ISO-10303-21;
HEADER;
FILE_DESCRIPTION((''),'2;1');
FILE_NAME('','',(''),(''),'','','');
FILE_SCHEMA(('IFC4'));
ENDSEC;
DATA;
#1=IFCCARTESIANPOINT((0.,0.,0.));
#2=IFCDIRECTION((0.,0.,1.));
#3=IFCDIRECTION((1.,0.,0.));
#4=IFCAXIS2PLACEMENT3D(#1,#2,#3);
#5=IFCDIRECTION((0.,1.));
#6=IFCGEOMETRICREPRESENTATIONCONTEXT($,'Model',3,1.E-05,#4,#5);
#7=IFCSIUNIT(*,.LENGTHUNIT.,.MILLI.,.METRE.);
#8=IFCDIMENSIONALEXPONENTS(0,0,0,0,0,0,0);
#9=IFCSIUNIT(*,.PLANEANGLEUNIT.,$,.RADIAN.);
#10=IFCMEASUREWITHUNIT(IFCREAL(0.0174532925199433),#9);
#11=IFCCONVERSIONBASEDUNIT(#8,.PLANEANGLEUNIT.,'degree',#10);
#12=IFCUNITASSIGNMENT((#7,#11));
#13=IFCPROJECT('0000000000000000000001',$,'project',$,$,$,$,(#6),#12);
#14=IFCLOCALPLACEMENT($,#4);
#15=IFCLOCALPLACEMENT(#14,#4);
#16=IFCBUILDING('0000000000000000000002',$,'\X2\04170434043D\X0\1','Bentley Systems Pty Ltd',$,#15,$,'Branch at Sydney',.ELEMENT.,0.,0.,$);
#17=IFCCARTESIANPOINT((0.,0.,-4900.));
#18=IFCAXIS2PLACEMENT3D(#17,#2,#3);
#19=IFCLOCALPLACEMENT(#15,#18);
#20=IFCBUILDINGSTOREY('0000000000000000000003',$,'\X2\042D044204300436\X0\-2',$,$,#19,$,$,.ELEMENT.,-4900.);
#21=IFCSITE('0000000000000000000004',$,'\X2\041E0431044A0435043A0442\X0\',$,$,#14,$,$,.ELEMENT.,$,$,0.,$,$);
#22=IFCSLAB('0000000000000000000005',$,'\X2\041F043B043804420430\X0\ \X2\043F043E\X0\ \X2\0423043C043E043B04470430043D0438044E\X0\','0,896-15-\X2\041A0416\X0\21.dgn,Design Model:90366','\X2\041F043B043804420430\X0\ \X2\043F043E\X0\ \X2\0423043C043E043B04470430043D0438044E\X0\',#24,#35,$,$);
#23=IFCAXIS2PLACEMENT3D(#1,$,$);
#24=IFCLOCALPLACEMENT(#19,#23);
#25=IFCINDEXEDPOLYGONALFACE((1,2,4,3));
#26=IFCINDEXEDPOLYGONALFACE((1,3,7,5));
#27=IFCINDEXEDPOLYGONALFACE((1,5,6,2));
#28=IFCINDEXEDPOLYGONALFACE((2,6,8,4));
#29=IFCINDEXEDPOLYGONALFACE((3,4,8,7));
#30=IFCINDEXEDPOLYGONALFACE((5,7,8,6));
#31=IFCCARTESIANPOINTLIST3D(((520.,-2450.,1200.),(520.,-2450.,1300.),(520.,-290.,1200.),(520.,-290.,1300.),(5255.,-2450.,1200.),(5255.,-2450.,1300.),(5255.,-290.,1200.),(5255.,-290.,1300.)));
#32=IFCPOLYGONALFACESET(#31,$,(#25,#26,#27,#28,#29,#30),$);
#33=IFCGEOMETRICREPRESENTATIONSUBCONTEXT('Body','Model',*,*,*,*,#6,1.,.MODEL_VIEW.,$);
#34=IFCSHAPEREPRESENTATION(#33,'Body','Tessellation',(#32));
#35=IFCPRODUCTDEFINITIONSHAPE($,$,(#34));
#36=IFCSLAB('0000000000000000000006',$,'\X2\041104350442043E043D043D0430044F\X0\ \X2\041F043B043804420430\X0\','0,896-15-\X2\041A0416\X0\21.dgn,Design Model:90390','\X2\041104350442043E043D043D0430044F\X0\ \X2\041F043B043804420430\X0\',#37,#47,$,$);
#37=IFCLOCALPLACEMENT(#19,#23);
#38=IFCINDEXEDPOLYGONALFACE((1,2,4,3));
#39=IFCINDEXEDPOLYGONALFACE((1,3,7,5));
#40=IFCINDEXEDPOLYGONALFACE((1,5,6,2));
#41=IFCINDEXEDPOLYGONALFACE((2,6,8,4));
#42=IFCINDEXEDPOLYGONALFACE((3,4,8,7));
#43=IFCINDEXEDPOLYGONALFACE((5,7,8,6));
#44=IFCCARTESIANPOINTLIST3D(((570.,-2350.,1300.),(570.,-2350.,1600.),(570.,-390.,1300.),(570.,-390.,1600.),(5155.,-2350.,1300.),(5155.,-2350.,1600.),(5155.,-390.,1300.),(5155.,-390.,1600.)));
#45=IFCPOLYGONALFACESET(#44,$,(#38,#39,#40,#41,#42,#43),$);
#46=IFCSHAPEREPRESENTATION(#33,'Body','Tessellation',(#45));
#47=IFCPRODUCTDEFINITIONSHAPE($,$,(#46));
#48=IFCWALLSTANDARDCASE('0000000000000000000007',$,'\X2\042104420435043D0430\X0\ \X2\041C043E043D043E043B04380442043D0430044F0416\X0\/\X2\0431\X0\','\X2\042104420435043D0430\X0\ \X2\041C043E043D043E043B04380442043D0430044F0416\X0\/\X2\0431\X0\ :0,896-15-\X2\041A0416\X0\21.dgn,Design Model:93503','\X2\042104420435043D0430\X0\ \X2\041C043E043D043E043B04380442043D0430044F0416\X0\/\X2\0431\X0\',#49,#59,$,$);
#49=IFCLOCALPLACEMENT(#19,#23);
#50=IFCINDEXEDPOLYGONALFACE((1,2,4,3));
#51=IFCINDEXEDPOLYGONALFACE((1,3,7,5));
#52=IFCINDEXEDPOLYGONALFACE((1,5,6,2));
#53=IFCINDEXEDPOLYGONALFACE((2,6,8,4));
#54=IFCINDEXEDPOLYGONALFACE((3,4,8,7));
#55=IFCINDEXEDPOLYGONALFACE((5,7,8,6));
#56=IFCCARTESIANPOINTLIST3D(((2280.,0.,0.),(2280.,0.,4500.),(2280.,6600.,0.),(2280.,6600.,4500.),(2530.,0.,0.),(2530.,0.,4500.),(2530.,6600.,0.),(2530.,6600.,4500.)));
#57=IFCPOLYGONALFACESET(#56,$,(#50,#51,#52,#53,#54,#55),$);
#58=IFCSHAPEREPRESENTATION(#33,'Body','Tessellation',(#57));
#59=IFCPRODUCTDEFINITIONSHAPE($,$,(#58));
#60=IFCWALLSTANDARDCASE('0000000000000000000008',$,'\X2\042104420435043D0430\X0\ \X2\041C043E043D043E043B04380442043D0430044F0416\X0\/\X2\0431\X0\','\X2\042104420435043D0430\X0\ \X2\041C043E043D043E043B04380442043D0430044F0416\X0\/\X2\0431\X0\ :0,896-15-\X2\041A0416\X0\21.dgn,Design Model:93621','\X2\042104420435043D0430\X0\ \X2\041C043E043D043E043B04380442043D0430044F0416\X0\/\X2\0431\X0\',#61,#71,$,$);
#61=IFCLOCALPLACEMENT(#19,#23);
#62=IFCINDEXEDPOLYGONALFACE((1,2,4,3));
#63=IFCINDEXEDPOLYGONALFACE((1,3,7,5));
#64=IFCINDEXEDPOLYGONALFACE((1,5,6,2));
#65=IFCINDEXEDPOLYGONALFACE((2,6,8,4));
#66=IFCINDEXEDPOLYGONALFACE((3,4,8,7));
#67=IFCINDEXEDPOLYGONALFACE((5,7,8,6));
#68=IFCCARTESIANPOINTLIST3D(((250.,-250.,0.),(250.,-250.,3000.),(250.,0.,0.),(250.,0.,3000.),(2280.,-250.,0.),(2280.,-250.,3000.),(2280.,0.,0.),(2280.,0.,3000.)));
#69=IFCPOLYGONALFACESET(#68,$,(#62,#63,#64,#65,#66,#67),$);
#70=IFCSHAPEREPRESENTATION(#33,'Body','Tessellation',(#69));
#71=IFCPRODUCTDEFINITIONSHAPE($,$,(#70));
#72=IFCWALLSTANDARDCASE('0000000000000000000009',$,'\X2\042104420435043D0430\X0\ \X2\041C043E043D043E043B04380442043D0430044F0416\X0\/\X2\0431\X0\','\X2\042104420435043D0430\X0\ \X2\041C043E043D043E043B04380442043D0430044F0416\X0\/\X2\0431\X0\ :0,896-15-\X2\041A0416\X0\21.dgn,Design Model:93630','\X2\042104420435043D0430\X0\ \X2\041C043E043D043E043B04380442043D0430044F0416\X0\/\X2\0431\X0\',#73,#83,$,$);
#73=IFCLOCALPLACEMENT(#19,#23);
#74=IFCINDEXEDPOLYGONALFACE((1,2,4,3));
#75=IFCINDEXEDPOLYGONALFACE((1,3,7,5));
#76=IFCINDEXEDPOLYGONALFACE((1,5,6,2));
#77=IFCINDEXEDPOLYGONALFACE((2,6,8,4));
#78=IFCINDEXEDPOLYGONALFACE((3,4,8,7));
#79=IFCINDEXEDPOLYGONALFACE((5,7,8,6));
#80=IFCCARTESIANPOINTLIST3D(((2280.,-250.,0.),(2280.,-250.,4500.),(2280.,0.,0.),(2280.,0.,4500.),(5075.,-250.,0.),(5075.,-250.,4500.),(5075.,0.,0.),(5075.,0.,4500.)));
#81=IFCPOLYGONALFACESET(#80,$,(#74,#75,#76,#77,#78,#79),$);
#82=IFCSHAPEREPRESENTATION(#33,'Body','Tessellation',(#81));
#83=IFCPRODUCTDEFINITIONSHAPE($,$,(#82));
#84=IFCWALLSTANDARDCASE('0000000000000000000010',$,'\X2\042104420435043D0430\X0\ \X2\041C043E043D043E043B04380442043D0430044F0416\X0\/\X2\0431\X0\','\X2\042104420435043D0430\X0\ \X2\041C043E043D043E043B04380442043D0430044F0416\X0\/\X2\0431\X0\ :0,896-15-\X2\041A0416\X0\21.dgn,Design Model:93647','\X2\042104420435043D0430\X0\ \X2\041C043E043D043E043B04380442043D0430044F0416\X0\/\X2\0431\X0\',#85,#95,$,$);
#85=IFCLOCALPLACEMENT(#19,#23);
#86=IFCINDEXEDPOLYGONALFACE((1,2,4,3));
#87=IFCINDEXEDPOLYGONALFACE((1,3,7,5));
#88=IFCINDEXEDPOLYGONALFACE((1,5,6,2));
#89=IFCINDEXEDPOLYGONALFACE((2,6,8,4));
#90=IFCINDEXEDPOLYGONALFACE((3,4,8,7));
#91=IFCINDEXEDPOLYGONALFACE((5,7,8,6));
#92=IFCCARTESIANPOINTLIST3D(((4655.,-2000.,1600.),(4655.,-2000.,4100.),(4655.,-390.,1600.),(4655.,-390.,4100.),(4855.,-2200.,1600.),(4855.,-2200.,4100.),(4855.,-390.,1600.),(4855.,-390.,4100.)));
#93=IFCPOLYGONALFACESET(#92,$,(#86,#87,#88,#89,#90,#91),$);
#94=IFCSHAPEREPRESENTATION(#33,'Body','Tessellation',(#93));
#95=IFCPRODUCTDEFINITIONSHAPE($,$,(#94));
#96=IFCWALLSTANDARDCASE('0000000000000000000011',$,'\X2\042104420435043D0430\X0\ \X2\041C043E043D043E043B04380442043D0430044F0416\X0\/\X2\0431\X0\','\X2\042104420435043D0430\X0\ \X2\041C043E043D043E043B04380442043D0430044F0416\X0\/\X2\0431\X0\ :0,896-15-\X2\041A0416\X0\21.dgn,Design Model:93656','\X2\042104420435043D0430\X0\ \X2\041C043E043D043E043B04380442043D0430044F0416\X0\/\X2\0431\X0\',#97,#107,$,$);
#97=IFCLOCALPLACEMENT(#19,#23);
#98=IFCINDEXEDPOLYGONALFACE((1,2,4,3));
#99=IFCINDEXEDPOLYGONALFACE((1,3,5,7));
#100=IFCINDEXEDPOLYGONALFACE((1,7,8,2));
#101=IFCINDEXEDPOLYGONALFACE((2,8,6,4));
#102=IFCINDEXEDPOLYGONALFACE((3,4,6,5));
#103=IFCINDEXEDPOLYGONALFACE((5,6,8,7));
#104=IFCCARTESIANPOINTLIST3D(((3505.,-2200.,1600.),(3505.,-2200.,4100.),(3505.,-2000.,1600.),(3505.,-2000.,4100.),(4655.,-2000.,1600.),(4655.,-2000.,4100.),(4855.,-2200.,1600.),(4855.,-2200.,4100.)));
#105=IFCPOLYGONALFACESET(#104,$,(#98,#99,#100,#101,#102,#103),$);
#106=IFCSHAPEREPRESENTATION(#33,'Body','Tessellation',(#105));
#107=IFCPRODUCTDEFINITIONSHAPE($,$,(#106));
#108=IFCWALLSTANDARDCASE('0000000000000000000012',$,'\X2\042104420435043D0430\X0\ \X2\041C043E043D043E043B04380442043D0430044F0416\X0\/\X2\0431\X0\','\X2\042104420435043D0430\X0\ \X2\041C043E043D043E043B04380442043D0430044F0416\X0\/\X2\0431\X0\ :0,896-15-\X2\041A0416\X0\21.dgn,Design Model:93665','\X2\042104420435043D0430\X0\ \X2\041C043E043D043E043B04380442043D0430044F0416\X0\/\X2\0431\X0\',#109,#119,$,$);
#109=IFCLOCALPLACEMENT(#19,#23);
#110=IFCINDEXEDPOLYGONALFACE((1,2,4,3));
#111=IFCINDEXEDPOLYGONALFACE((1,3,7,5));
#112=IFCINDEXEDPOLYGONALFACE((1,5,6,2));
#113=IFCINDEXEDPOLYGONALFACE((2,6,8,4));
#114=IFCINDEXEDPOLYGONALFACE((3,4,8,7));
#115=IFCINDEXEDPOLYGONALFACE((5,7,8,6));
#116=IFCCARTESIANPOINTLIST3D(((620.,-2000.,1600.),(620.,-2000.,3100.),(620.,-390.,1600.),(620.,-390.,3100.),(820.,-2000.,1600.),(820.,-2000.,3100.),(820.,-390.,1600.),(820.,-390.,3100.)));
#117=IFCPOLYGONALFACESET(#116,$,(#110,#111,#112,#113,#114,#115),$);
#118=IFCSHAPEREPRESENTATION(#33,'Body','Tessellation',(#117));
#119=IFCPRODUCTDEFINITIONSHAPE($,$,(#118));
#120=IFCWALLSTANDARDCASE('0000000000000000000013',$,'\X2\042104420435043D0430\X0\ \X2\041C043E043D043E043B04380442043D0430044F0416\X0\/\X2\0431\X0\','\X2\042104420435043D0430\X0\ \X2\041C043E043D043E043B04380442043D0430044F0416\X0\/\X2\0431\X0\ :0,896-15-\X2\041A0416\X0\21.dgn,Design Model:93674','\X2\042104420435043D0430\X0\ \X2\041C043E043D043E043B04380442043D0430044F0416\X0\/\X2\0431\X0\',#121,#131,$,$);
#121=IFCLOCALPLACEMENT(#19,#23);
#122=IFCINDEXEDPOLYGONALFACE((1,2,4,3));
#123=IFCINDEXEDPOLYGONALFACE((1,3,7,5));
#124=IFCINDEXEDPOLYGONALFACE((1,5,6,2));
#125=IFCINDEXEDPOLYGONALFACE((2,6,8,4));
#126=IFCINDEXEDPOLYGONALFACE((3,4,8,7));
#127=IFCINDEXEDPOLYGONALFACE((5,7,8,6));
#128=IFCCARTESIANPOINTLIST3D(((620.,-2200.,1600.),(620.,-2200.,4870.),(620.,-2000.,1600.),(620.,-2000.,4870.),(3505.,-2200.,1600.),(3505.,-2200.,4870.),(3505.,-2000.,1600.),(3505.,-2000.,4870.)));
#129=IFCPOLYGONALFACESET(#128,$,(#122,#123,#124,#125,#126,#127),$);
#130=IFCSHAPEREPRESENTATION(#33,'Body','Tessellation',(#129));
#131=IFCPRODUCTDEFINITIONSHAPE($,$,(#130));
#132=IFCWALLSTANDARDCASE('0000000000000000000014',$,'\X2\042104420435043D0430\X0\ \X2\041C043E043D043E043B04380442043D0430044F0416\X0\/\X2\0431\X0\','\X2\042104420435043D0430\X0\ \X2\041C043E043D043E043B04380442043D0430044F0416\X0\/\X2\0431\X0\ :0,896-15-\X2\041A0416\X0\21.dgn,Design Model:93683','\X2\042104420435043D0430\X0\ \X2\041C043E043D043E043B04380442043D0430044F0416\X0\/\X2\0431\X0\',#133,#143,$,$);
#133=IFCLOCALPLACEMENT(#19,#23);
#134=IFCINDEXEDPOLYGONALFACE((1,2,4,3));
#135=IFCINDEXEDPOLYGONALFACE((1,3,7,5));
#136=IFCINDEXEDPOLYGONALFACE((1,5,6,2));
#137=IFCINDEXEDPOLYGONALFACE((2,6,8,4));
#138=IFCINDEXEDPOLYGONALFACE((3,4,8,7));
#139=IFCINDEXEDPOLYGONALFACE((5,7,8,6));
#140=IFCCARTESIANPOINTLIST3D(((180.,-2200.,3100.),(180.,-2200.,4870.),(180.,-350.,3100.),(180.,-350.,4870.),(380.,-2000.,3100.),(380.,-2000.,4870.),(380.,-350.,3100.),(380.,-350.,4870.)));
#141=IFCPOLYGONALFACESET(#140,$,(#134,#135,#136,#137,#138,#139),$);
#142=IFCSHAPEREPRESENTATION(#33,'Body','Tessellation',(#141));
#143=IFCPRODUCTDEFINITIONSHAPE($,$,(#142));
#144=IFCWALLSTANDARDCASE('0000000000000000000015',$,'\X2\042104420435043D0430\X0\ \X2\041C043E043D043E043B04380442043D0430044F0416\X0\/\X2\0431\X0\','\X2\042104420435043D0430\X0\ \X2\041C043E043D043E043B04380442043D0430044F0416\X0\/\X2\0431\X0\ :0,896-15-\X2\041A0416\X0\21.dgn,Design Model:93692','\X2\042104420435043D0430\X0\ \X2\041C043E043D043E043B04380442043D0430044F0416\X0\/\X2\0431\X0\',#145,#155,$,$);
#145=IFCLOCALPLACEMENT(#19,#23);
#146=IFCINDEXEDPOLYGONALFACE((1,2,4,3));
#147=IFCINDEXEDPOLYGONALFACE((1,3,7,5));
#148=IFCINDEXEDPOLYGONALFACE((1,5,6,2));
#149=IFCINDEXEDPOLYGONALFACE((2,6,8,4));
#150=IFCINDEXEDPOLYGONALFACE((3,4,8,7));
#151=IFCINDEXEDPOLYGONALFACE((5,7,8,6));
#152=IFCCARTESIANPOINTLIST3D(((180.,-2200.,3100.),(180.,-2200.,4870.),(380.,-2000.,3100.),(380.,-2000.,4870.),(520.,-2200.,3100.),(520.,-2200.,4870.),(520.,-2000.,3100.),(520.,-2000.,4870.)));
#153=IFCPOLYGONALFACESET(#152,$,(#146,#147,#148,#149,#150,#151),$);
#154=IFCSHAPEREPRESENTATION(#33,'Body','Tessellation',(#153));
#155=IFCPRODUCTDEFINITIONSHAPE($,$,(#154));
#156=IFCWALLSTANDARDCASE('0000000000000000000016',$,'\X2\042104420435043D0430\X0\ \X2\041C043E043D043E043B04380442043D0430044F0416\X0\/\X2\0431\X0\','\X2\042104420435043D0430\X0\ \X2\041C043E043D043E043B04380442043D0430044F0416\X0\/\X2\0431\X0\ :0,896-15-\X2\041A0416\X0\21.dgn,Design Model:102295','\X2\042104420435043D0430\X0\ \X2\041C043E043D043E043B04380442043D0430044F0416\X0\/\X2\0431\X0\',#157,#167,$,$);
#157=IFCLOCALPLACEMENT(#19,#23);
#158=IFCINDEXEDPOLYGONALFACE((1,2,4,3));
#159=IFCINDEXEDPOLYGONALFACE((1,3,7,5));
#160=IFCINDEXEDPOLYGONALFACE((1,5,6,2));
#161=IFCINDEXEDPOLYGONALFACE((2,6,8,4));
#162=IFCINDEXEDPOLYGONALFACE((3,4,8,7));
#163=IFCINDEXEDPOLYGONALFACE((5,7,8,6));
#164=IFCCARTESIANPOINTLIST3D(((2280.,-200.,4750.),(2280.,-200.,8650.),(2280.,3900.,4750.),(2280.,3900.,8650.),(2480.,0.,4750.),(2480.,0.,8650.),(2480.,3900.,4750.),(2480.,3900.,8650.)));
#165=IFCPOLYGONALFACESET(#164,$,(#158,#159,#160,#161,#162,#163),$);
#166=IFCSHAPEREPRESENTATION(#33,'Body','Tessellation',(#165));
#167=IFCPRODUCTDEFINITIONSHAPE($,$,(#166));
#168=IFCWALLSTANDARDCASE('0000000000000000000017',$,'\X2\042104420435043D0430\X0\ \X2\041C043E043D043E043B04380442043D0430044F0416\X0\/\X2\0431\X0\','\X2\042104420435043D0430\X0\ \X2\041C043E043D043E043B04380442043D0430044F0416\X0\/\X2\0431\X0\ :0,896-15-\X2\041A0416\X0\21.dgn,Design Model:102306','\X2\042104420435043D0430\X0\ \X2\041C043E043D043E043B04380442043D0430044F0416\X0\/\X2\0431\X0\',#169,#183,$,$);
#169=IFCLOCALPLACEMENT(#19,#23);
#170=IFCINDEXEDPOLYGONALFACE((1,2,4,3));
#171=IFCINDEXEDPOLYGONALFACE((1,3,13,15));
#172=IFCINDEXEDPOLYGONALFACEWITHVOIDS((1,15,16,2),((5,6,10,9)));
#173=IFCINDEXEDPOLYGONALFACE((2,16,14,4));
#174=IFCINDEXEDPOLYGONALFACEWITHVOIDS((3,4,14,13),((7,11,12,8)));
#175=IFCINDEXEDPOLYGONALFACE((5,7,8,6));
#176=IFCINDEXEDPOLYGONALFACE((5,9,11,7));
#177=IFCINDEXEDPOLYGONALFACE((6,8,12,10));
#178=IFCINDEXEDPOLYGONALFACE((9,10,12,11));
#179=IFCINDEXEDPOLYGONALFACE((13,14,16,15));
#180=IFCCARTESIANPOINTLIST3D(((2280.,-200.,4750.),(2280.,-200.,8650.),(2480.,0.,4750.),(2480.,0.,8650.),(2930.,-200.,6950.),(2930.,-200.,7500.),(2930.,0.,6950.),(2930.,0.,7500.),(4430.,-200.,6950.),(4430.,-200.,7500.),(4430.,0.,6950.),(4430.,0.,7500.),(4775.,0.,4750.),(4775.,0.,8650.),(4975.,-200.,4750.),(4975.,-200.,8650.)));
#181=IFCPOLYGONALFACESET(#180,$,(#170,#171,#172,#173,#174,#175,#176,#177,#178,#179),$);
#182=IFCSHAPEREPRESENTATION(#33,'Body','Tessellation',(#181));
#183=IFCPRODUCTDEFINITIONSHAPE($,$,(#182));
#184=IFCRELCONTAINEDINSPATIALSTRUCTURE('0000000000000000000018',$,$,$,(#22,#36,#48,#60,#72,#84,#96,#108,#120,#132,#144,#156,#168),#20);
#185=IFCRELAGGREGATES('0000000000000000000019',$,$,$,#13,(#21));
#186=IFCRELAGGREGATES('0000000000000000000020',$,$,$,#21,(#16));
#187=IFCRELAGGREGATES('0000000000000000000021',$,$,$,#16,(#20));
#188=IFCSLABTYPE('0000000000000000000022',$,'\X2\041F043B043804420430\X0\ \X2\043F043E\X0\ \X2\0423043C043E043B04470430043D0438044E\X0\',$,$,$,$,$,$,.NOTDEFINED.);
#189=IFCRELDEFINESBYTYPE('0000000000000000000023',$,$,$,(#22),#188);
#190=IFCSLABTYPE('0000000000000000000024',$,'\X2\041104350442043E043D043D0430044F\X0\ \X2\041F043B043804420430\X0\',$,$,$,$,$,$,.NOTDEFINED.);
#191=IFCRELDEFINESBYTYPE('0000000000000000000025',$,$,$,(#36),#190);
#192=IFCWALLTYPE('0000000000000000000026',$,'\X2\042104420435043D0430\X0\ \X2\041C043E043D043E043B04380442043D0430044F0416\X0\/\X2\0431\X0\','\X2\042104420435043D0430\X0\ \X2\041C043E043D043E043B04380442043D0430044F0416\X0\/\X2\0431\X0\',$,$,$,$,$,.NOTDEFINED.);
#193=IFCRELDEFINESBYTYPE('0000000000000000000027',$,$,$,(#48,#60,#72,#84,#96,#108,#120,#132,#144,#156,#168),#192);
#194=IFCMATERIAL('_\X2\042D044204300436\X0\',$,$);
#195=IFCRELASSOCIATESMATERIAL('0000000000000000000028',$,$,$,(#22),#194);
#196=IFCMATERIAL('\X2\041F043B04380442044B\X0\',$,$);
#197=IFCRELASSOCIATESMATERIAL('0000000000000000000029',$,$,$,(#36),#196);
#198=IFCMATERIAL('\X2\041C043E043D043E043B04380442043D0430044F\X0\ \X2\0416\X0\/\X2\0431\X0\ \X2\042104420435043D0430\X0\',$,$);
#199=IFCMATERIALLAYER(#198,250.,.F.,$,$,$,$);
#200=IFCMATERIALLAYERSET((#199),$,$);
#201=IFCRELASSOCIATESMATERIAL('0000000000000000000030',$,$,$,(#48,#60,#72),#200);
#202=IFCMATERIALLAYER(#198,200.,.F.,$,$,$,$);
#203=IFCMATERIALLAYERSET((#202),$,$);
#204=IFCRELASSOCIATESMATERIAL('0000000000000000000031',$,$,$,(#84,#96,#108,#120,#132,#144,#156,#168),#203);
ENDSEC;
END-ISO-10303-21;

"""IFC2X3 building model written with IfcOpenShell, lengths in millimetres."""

from ifc_helpers import new_model, entity, si_unit, converted_unit, direction, frame, frame_2d, origin_with_axes, place, context, subcontext, project, spatial, polyline, rectangle, outline, extrude, material, layer, layer_set, layer_usage, type_object, element, save


model = new_model("IFC2X3")

# Units and contexts
model_context = context("Model", 3, precision=1e-05, world=origin_with_axes(), true_north=direction((0.0, 1.0)))
body_context = subcontext(model_context, "Body", "Model", "MODEL_VIEW", scale=1.0)
ifc_project = project(units=[si_unit("LENGTHUNIT", "METRE", prefix="MILLI"), converted_unit("PLANEANGLEUNIT", "degree", entity("IfcReal", 0.0174532925199433), si_unit("PLANEANGLEUNIT", "RADIAN"), dimensions=[0, 0, 0, 0, 0, 0, 0])], contexts=[model_context])

# Site, building, storey
site_placement = place(None, origin_with_axes())
site = spatial("IfcSite", under=ifc_project, at=site_placement, Name="Объект", CompositionType="ELEMENT", RefElevation=0.0)
building_placement = place(site_placement, origin_with_axes())
building = spatial("IfcBuilding", under=site, at=building_placement, Name="Здн1", Description="Bentley Systems Pty Ltd", LongName="Branch at Sydney", CompositionType="ELEMENT", ElevationOfRefHeight=0.0, ElevationOfTerrain=0.0)
storey_placement = place(building_placement, frame((0.0, 0.0, -4900.0), z_axis=(0.0, 0.0, 1.0), x_axis=(1.0, 0.0, 0.0)))
storey = spatial("IfcBuildingStorey", under=building, at=storey_placement, Name="Этаж-2", CompositionType="ELEMENT", Elevation=-4900.0)

# Slabs
ifc_material_1 = material(Name="_Этаж")
slab_type_1 = type_object("IfcSlabType", Name="Плита по Умолчанию", PredefinedType="NOTDEFINED")
slab_1_placement = place(storey_placement, frame((5255.0, -290.0, 1300.0), z_axis=(0.0, 0.0, -1.0), x_axis=(0.0, -1.0, 0.0)))
element("IfcSlab", 1, at=slab_1_placement, inside=storey, type_object=slab_type_1, material=ifc_material_1, Name="Плита по Умолчанию", Description="0,896-15-КЖ21.dgn,Design Model:90366", ObjectType="Плита по Умолчанию", context=body_context, shape_type="SweptSolid", body=[
    extrude(rectangle(XDim=2160.0, YDim=4735.0, at=frame_2d((1080.0, 2367.5), x_axis=(1.0, 0.0))), origin_with_axes(), (0.0, 0.0, 1.0), 100.0),
])
ifc_material_2 = material(Name="Плиты")
slab_type_2 = type_object("IfcSlabType", Name="Бетонная Плита", PredefinedType="NOTDEFINED")
slab_2_placement = place(storey_placement, frame((570.0, -390.0, 1600.0), z_axis=(0.0, 0.0, -1.0), x_axis=(1.0, 0.0, 0.0)))
element("IfcSlab", 2, at=slab_2_placement, inside=storey, type_object=slab_type_2, material=ifc_material_2, Name="Бетонная Плита", Description="0,896-15-КЖ21.dgn,Design Model:90390", ObjectType="Бетонная Плита", context=body_context, shape_type="SweptSolid", body=[
    extrude(rectangle(XDim=4585.0, YDim=1960.0, at=frame_2d((2292.5, 980.0), x_axis=(1.0, 0.0))), origin_with_axes(), (0.0, 0.0, 1.0), 300.0),
])

# Walls
ifc_material_3 = material(Name="Монолитная Ж/б Стена")
ifc_layer_1 = layer(ifc_material_3, 250.0, ventilated=False)
ifc_layer_set_1 = layer_set([ifc_layer_1])
ifc_layer_usage_1 = layer_usage(ifc_layer_set_1, "AXIS2", "POSITIVE", 0.0)
wall_type = type_object("IfcWallType", Name="Стена МонолитнаяЖ/б", Description="Стена МонолитнаяЖ/б", PredefinedType="NOTDEFINED")
wall_1_placement = place(storey_placement, frame((2530.0, 0.0, 0.0), z_axis=(0.0, 0.0, 1.0), x_axis=(0.0, 1.0, 0.0)))
element("IfcWallStandardCase", 3, at=wall_1_placement, inside=storey, type_object=wall_type, material=ifc_layer_usage_1, Name="Стена МонолитнаяЖ/б", Description="Стена МонолитнаяЖ/б :0,896-15-КЖ21.dgn,Design Model:93503", ObjectType="Стена МонолитнаяЖ/б", context=body_context, shape_type="SweptSolid", body=[
    extrude(rectangle(XDim=250.0, YDim=6600.0, at=frame_2d((3300.0, 125.0), x_axis=(0.0, -1.0))), origin_with_axes(), (0.0, 0.0, 1.0), 4500.0),
])
wall_2_placement = place(storey_placement, frame((250.0, -250.0, 0.0), z_axis=(0.0, 0.0, 1.0), x_axis=(1.0, 0.0, 0.0)))
element("IfcWallStandardCase", 4, at=wall_2_placement, inside=storey, type_object=wall_type, material=ifc_layer_usage_1, Name="Стена МонолитнаяЖ/б", Description="Стена МонолитнаяЖ/б :0,896-15-КЖ21.dgn,Design Model:93621", ObjectType="Стена МонолитнаяЖ/б", context=body_context, shape_type="SweptSolid", body=[
    extrude(rectangle(XDim=2030.0, YDim=250.0, at=frame_2d((1015.0, 125.0), x_axis=(1.0, 0.0))), origin_with_axes(), (0.0, 0.0, 1.0), 3000.0),
])
wall_3_placement = place(storey_placement, frame((2280.0, -250.0, 0.0), z_axis=(0.0, 0.0, 1.0), x_axis=(1.0, 0.0, 0.0)))
element("IfcWallStandardCase", 5, at=wall_3_placement, inside=storey, type_object=wall_type, material=ifc_layer_usage_1, Name="Стена МонолитнаяЖ/б", Description="Стена МонолитнаяЖ/б :0,896-15-КЖ21.dgn,Design Model:93630", ObjectType="Стена МонолитнаяЖ/б", context=body_context, shape_type="SweptSolid", body=[
    extrude(rectangle(XDim=2795.0, YDim=250.0, at=frame_2d((1397.5, 125.0), x_axis=(1.0, 0.0))), origin_with_axes(), (0.0, 0.0, 1.0), 4500.0),
])
ifc_layer_2 = layer(ifc_material_3, 200.0, ventilated=False)
ifc_layer_set_2 = layer_set([ifc_layer_2])
ifc_layer_usage_2 = layer_usage(ifc_layer_set_2, "AXIS2", "POSITIVE", 0.0)
wall_4_placement = place(storey_placement, frame((4655.0, -390.0, 1600.0), z_axis=(0.0, 0.0, 1.0), x_axis=(0.0, -1.0, 0.0)))
element("IfcWallStandardCase", 6, at=wall_4_placement, inside=storey, type_object=wall_type, material=ifc_layer_usage_2, Name="Стена МонолитнаяЖ/б", Description="Стена МонолитнаяЖ/б :0,896-15-КЖ21.dgn,Design Model:93647", ObjectType="Стена МонолитнаяЖ/б", context=body_context, shape_type="SweptSolid", body=[
    extrude(outline(polyline([(1810.0, 200.0), (0.0, 200.0), (0.0, 0.0), (1610.0, 0.0), (1810.0, 200.0)])), origin_with_axes(), (0.0, 0.0, 1.0), 2500.0),
])
wall_5_placement = place(storey_placement, frame((4655.0, -2000.0, 1600.0), z_axis=(0.0, 0.0, 1.0), x_axis=(-1.0, 0.0, 0.0)))
element("IfcWallStandardCase", 7, at=wall_5_placement, inside=storey, type_object=wall_type, material=ifc_layer_usage_2, Name="Стена МонолитнаяЖ/б", Description="Стена МонолитнаяЖ/б :0,896-15-КЖ21.dgn,Design Model:93656", ObjectType="Стена МонолитнаяЖ/б", context=body_context, shape_type="SweptSolid", body=[
    extrude(outline(polyline([(-200.0, 200.0), (0.0, 0.0), (1150.0, 0.0), (1150.0, 200.0), (-200.0, 200.0)])), origin_with_axes(), (0.0, 0.0, 1.0), 2500.0),
])
wall_6_placement = place(storey_placement, frame((620.0, -390.0, 1600.0), z_axis=(0.0, 0.0, 1.0), x_axis=(0.0, -1.0, 0.0)))
element("IfcWallStandardCase", 8, at=wall_6_placement, inside=storey, type_object=wall_type, material=ifc_layer_usage_2, Name="Стена МонолитнаяЖ/б", Description="Стена МонолитнаяЖ/б :0,896-15-КЖ21.dgn,Design Model:93665", ObjectType="Стена МонолитнаяЖ/б", context=body_context, shape_type="SweptSolid", body=[
    extrude(rectangle(XDim=1610.0, YDim=200.0, at=frame_2d((805.0, 100.0), x_axis=(-1.0, 0.0))), origin_with_axes(), (0.0, 0.0, 1.0), 1500.0),
])
wall_7_placement = place(storey_placement, frame((620.0, -2200.0, 1600.0), z_axis=(0.0, 0.0, 1.0), x_axis=(1.0, 0.0, 0.0)))
element("IfcWallStandardCase", 9, at=wall_7_placement, inside=storey, type_object=wall_type, material=ifc_layer_usage_2, Name="Стена МонолитнаяЖ/б", Description="Стена МонолитнаяЖ/б :0,896-15-КЖ21.dgn,Design Model:93674", ObjectType="Стена МонолитнаяЖ/б", context=body_context, shape_type="SweptSolid", body=[
    extrude(rectangle(XDim=2885.0, YDim=200.0, at=frame_2d((1442.5, 100.0), x_axis=(1.0, 0.0))), origin_with_axes(), (0.0, 0.0, 1.0), 3270.0),
])
wall_8_placement = place(storey_placement, frame((180.0, -350.0, 3100.0), z_axis=(0.0, 0.0, 1.0), x_axis=(0.0, -1.0, 0.0)))
element("IfcWallStandardCase", 10, at=wall_8_placement, inside=storey, type_object=wall_type, material=ifc_layer_usage_2, Name="Стена МонолитнаяЖ/б", Description="Стена МонолитнаяЖ/б :0,896-15-КЖ21.dgn,Design Model:93683", ObjectType="Стена МонолитнаяЖ/б", context=body_context, shape_type="SweptSolid", body=[
    extrude(outline(polyline([(1650.0, 200.0), (0.0, 200.0), (0.0, 0.0), (1850.0, 0.0), (1650.0, 200.0)])), origin_with_axes(), (0.0, 0.0, 1.0), 1770.0),
])
wall_9_placement = place(storey_placement, frame((180.0, -2200.0, 3100.0), z_axis=(0.0, 0.0, 1.0), x_axis=(1.0, 0.0, 0.0)))
element("IfcWallStandardCase", 11, at=wall_9_placement, inside=storey, type_object=wall_type, material=ifc_layer_usage_2, Name="Стена МонолитнаяЖ/б", Description="Стена МонолитнаяЖ/б :0,896-15-КЖ21.dgn,Design Model:93692", ObjectType="Стена МонолитнаяЖ/б", context=body_context, shape_type="SweptSolid", body=[
    extrude(outline(polyline([(200.0, 200.0), (0.0, 0.0), (340.0, 0.0), (340.0, 200.0), (200.0, 200.0)])), origin_with_axes(), (0.0, 0.0, 1.0), 1770.0),
])
wall_10_placement = place(storey_placement, frame((2280.0, -200.0, 4750.0), z_axis=(0.0, 0.0, 1.0), x_axis=(0.0, 1.0, 0.0)))
element("IfcWallStandardCase", 12, at=wall_10_placement, inside=storey, type_object=wall_type, material=ifc_layer_usage_2, Name="Стена МонолитнаяЖ/б", Description="Стена МонолитнаяЖ/б :0,896-15-КЖ21.dgn,Design Model:102295", ObjectType="Стена МонолитнаяЖ/б", context=body_context, shape_type="SweptSolid", body=[
    extrude(outline(polyline([(0.0, 0.0), (200.0, -200.0), (4100.0, -200.0), (4100.0, 0.0), (0.0, 0.0)])), origin_with_axes(), (0.0, 0.0, 1.0), 3900.0),
])

# Wall, opening
wall_11_placement = place(storey_placement, frame((2280.0, -200.0, 4750.0), z_axis=(0.0, 0.0, 1.0), x_axis=(1.0, 0.0, 0.0)))
wall_11 = element("IfcWallStandardCase", 13, at=wall_11_placement, inside=storey, type_object=wall_type, material=ifc_layer_usage_2, Name="Стена МонолитнаяЖ/б", Description="Стена МонолитнаяЖ/б :0,896-15-КЖ21.dgn,Design Model:102306", ObjectType="Стена МонолитнаяЖ/б", context=body_context, shape_type="SweptSolid", body=[
    extrude(outline(polyline([(2495.0, 200.0), (200.0, 200.0), (0.0, 0.0), (2695.0, 0.0), (2495.0, 200.0)])), origin_with_axes(), (0.0, 0.0, 1.0), 3900.0),
])
opening_placement = place(wall_11_placement, frame((650.0, 0.0, 2200.0), z_axis=(0.0, 0.0, 1.0), x_axis=(1.0, 0.0, 0.0)))
element("IfcOpeningElement", 14, at=opening_placement, cuts=wall_11, ObjectType="Opening", context=body_context, shape_type="SweptSolid", body=[
    extrude(rectangle(XDim=550.0, YDim=1500.0, at=frame_2d((-750.0, 275.0), x_axis=(0.0, -1.0))), frame((0.0, 0.0, 0.0), z_axis=(0.0, 1.0, 0.0), x_axis=(-1.0, 0.0, 0.0)), (0.0, 0.0, 1.0), 200.0),
])

save(model, "model.ifc")
